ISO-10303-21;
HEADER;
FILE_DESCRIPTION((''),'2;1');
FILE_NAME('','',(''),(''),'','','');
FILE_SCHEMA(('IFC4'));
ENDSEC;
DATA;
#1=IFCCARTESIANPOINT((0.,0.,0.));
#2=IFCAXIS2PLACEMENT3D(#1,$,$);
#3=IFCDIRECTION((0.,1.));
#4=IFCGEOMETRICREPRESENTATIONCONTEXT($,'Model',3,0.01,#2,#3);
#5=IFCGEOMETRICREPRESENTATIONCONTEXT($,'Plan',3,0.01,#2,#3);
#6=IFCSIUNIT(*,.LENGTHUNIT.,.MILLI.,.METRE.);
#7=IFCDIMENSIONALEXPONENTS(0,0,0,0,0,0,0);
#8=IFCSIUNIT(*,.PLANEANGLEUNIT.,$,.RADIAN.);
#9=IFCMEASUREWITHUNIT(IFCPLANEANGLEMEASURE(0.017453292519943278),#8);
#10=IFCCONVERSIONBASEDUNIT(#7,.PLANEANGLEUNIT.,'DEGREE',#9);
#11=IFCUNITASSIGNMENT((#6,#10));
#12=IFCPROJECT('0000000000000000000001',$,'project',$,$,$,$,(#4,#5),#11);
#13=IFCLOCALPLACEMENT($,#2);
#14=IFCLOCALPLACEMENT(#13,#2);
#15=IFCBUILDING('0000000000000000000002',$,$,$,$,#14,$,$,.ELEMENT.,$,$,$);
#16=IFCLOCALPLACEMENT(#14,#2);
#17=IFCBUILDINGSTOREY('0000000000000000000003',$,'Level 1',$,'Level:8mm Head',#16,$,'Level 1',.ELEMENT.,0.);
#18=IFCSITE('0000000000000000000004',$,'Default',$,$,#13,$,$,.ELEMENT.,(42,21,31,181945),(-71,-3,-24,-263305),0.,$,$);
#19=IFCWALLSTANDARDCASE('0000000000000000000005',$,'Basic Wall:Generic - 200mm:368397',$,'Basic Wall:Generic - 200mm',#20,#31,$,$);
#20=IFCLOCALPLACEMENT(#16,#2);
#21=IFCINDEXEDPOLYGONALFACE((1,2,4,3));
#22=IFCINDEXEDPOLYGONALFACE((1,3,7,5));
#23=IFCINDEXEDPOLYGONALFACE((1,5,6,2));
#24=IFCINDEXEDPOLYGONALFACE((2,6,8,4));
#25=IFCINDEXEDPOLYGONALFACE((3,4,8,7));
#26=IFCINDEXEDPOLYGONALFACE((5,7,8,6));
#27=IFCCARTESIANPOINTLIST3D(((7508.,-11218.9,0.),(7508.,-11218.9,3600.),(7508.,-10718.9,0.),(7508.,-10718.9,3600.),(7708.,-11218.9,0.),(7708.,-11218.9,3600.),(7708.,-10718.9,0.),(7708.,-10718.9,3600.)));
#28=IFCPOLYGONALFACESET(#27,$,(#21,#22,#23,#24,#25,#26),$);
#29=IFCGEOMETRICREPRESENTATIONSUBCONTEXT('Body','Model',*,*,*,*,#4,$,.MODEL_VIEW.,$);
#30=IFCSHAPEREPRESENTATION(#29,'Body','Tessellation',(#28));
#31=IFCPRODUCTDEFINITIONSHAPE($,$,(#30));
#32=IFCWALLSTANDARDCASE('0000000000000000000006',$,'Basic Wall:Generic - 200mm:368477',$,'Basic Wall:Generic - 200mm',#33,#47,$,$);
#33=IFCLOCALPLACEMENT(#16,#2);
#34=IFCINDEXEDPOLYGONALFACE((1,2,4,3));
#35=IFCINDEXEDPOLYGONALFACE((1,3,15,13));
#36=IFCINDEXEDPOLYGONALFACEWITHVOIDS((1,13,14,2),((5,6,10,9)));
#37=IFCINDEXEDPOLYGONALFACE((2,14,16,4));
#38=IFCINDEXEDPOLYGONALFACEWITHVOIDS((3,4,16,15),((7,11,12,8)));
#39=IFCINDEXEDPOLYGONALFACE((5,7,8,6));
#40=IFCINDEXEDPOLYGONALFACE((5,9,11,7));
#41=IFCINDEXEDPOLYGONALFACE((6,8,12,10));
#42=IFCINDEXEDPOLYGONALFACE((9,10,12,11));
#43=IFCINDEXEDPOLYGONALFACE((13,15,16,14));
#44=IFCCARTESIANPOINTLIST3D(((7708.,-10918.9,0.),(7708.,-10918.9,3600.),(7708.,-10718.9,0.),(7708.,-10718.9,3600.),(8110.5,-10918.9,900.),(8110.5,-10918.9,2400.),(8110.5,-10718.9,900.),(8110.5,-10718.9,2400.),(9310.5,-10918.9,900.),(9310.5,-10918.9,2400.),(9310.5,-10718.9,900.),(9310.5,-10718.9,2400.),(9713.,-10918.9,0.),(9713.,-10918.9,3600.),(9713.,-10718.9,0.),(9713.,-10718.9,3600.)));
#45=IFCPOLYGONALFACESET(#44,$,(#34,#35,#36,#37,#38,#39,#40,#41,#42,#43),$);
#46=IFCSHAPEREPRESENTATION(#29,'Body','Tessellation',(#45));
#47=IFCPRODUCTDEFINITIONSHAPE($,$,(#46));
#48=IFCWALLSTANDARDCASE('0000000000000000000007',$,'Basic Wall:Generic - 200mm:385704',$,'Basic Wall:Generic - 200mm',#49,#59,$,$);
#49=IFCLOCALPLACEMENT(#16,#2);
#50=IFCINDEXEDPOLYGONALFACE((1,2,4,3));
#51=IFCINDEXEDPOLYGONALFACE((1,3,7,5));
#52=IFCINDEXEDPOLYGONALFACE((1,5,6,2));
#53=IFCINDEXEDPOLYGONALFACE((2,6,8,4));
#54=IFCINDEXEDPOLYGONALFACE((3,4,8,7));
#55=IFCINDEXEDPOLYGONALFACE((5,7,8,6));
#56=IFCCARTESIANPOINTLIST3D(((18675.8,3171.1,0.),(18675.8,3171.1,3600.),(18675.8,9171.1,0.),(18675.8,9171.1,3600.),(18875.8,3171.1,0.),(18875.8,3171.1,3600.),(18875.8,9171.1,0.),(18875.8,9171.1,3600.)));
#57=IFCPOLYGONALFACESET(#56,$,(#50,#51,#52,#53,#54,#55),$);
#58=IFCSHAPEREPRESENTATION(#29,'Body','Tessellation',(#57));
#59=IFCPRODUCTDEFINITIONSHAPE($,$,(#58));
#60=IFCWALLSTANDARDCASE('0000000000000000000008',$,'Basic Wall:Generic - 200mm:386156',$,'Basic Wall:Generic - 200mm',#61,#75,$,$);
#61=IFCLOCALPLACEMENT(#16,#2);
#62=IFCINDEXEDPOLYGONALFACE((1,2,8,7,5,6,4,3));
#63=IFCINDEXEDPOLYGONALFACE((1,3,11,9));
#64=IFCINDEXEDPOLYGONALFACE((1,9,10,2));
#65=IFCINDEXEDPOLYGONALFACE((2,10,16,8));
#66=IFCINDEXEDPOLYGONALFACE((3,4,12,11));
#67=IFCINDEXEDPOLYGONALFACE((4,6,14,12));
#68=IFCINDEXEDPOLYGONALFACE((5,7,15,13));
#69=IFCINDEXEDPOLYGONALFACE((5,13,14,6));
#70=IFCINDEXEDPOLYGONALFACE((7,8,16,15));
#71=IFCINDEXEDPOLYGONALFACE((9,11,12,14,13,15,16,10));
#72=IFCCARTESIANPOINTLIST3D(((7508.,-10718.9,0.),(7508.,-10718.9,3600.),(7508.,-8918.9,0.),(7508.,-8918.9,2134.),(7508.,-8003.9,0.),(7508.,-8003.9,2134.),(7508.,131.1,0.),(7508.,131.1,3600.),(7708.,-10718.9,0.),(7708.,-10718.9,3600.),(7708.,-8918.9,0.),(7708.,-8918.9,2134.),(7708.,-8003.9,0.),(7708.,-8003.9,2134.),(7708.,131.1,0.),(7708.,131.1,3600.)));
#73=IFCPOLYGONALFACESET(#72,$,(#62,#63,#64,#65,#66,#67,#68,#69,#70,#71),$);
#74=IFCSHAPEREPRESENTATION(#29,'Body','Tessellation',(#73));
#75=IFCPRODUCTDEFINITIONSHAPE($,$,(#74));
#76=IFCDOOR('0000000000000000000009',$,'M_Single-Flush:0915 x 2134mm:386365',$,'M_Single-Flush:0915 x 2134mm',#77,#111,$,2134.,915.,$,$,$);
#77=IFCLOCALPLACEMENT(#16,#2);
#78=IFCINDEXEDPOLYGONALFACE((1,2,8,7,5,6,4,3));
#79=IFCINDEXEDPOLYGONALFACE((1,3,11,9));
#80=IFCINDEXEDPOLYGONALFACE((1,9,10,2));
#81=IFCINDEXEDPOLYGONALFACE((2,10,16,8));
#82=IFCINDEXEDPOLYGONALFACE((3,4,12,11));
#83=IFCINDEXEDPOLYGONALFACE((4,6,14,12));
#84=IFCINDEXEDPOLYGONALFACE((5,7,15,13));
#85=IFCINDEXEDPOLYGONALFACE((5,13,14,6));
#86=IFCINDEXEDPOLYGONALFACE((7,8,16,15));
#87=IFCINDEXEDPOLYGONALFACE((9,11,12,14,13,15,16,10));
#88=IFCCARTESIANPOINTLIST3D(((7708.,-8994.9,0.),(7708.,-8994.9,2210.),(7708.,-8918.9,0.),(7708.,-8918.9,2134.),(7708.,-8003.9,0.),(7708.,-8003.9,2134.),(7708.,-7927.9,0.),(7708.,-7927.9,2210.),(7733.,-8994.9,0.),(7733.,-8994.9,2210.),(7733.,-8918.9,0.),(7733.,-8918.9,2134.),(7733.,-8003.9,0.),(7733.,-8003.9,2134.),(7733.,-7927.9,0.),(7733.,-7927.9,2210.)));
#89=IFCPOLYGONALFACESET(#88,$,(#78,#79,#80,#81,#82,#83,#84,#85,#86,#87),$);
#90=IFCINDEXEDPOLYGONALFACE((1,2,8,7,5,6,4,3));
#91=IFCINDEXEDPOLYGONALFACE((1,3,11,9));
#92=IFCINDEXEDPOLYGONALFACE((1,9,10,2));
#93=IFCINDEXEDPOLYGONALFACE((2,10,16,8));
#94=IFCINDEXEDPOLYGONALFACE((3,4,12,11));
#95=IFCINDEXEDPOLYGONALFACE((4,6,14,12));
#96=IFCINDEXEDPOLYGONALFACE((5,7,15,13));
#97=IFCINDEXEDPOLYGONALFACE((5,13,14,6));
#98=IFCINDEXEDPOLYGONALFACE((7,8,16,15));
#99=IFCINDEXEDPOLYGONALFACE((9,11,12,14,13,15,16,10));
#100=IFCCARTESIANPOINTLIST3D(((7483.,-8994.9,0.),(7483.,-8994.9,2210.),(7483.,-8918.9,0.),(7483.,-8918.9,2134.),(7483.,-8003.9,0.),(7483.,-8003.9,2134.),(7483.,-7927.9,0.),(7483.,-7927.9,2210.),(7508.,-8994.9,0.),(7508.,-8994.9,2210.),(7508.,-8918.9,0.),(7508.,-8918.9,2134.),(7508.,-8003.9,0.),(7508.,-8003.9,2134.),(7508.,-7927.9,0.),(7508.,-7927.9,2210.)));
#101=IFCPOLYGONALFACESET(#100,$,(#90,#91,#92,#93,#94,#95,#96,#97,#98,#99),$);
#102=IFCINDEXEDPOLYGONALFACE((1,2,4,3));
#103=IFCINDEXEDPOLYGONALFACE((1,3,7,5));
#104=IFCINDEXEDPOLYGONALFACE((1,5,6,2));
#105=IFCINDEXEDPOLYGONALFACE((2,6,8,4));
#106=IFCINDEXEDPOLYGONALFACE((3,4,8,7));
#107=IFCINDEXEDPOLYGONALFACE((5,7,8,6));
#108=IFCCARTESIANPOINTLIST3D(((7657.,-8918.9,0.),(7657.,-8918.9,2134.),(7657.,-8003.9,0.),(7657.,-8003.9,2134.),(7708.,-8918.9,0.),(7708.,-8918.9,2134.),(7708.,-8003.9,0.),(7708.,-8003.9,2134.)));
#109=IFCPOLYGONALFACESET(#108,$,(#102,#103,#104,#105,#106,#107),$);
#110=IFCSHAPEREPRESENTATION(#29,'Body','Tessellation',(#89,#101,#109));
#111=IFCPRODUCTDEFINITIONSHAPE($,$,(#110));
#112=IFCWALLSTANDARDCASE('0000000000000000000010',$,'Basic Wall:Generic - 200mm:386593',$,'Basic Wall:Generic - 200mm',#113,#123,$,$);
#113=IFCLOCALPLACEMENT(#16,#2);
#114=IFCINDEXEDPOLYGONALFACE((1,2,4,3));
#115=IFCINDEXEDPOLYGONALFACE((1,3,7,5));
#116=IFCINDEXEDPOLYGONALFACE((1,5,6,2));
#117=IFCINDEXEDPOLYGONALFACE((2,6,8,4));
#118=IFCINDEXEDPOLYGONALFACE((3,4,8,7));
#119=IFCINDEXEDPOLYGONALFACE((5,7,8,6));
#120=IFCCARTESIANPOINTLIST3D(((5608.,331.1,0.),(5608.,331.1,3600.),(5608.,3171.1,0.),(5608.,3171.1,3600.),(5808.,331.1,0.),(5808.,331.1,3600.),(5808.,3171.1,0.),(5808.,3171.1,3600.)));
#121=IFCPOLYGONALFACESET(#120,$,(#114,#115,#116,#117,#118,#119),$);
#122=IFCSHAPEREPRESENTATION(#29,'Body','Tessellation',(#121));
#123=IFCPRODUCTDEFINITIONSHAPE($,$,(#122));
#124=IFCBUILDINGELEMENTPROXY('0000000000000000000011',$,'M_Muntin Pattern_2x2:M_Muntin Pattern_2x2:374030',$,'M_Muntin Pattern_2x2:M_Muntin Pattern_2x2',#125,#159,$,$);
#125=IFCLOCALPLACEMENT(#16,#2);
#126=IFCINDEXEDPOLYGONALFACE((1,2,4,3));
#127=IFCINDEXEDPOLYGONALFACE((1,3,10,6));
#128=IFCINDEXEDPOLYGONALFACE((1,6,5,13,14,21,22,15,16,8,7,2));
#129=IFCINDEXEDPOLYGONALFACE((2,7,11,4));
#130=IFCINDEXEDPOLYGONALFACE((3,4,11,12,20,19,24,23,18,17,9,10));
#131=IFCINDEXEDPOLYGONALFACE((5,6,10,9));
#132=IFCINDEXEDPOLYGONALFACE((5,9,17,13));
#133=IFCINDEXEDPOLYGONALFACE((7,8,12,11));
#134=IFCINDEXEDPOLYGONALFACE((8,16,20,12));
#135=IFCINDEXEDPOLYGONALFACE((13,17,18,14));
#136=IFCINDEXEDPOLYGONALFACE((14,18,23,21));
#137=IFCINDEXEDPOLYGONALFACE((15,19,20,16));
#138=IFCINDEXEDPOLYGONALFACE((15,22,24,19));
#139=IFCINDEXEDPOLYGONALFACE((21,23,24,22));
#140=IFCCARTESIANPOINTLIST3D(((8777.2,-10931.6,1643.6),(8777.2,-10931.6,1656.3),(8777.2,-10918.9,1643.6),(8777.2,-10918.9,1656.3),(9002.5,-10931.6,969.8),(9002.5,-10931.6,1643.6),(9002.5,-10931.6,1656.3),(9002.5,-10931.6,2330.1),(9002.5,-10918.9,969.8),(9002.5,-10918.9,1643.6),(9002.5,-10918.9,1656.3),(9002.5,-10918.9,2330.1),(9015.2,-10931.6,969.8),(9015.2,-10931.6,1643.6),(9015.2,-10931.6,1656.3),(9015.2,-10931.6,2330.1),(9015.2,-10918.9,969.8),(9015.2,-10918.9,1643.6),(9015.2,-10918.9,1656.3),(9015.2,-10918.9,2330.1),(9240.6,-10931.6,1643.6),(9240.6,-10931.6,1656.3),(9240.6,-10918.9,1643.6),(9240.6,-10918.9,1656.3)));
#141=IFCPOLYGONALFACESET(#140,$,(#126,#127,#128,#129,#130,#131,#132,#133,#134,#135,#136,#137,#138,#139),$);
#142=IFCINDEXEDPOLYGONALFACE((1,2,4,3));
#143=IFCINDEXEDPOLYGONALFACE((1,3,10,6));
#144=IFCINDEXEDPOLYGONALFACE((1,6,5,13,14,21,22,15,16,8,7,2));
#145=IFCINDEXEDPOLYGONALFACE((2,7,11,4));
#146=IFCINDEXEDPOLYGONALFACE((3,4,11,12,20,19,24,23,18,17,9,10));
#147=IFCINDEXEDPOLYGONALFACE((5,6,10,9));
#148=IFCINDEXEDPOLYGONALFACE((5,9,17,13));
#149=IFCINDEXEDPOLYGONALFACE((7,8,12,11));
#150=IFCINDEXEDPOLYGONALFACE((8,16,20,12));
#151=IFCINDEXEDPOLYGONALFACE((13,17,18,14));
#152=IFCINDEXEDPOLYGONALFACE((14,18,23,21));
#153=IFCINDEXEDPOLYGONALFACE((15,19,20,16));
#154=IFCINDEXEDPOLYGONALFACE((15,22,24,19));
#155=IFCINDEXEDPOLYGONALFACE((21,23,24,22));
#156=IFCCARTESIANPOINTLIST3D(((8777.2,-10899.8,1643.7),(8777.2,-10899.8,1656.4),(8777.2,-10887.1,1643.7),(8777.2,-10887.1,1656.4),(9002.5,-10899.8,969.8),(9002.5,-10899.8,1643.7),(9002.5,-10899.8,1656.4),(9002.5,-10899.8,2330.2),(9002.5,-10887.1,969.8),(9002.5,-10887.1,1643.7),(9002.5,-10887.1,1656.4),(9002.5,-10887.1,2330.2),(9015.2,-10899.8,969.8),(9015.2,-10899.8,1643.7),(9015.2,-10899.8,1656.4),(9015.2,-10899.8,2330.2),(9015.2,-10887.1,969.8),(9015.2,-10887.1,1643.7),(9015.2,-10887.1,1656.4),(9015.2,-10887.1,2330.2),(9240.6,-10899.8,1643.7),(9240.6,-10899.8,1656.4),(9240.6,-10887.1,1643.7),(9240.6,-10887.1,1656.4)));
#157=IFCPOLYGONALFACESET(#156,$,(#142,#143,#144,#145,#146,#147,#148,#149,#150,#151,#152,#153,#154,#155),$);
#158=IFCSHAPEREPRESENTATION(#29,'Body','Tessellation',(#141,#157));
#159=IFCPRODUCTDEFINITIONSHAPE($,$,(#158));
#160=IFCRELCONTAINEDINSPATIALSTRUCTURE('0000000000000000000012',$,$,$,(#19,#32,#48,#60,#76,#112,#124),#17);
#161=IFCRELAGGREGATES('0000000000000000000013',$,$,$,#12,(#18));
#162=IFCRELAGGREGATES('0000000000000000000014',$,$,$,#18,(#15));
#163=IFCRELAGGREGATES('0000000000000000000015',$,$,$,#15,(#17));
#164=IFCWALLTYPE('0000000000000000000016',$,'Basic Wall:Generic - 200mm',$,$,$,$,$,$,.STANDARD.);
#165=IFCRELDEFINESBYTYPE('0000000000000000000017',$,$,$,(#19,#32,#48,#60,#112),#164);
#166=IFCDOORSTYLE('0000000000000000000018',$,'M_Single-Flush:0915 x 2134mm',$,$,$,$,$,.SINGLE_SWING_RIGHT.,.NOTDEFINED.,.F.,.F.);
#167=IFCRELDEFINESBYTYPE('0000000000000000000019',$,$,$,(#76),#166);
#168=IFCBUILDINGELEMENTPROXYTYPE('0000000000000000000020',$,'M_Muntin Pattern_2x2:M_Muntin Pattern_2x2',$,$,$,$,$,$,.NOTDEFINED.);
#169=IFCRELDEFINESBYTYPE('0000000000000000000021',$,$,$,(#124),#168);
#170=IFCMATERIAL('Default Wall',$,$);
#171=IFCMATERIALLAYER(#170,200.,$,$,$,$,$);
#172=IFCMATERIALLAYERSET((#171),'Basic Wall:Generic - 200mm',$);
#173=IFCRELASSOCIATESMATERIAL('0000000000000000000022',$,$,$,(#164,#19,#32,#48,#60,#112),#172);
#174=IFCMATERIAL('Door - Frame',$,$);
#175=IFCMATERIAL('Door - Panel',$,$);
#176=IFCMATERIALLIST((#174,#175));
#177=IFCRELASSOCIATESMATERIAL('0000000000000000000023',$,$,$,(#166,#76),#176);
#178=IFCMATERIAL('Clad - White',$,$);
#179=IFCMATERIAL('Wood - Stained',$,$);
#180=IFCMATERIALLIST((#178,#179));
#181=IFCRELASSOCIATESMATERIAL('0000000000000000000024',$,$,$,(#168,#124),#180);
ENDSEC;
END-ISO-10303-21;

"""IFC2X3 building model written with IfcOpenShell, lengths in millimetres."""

from ifc_helpers import new_model, entity, si_unit, converted_unit, direction, frame, frame_2d, origin, place, context, subcontext, project, spatial, polyline, rectangle, outline, extrude, source, transform, mapped, material, material_list, layer, layer_set, layer_usage, type_object, type_shapes, element, fill, save


model = new_model("IFC2X3")

# Units and contexts
model_context = context("Model", 3, precision=0.01, world=origin(), true_north=direction((0.0, 1.0)))
plan_context = context("Plan", 3, precision=0.01, world=origin(), true_north=direction((0.0, 1.0)))
body_context = subcontext(model_context, "Body", "Model", "MODEL_VIEW")
ifc_project = project(units=[si_unit("LENGTHUNIT", "METRE", prefix="MILLI"), converted_unit("PLANEANGLEUNIT", "DEGREE", entity("IfcPlaneAngleMeasure", 0.017453292519943278), si_unit("PLANEANGLEUNIT", "RADIAN"), dimensions=[0, 0, 0, 0, 0, 0, 0])], contexts=[model_context, plan_context])

# Site, building, storey
site_placement = place(None, origin())
site = spatial("IfcSite", under=ifc_project, at=site_placement, Name="Default", CompositionType="ELEMENT", RefLatitude=(42, 21, 31, 181945), RefLongitude=(-71, -3, -24, -263305), RefElevation=0.0)
building_placement = place(site_placement, origin())
building = spatial("IfcBuilding", under=site, at=building_placement, CompositionType="ELEMENT")
storey_placement = place(building_placement, origin())
storey = spatial("IfcBuildingStorey", under=building, at=storey_placement, Name="Level 1", ObjectType="Level:8mm Head", LongName="Level 1", CompositionType="ELEMENT", Elevation=0.0)

# Wall
ifc_material_1 = material(Name="Default Wall")
ifc_layer = layer(ifc_material_1, 200.0)
ifc_layer_set = layer_set([ifc_layer], Name="Basic Wall:Generic - 200mm")
ifc_layer_usage_1 = layer_usage(ifc_layer_set, "AXIS2", "NEGATIVE", 100.0)
wall_type = type_object("IfcWallType", Name="Basic Wall:Generic - 200mm", PredefinedType="STANDARD", material=ifc_layer_set)
wall_1_placement = place(storey_placement, frame((7608.0, -11218.9, 0.0), z_axis=(0.0, 0.0, 1.0), x_axis=(0.0, 1.0, 0.0)))
element("IfcWallStandardCase", 1, at=wall_1_placement, inside=storey, type_object=wall_type, material=ifc_layer_usage_1, Name="Basic Wall:Generic - 200mm:368397", ObjectType="Basic Wall:Generic - 200mm", context=body_context, shape_type="SweptSolid", body=[
    extrude(rectangle(XDim=500.0, YDim=200.0, at=frame_2d((250.0, 0.0), x_axis=(-1.0, 0.0))), origin(), (0.0, 0.0, 1.0), 3600.0),
])

# Wall, opening
ifc_layer_usage_2 = layer_usage(ifc_layer_set, "AXIS2", "NEGATIVE", 100.0)
wall_2_placement = place(storey_placement, frame((7708.0, -10818.9, 0.0)))
wall_2 = element("IfcWallStandardCase", 2, at=wall_2_placement, inside=storey, type_object=wall_type, material=ifc_layer_usage_2, Name="Basic Wall:Generic - 200mm:368477", ObjectType="Basic Wall:Generic - 200mm", context=body_context, shape_type="SweptSolid", body=[
    extrude(rectangle(XDim=2005.0, YDim=200.0, at=frame_2d((1002.5, 0.0), x_axis=(-1.0, 0.0))), origin(), (0.0, 0.0, 1.0), 3600.0),
])
opening_1_placement = place(wall_2_placement, frame((1602.5, 100.0, 900.0)))
element("IfcOpeningElement", 3, at=opening_1_placement, cuts=wall_2, ObjectType="Opening", context=body_context, shape_type="SweptSolid", body=[
    extrude(rectangle(XDim=1500.0, YDim=1200.0, at=frame_2d((750.0, 600.0), x_axis=(-1.0, 0.0))), frame((0.0, 0.0, 0.0), z_axis=(0.0, -1.0, 0.0), x_axis=(0.0, 0.0, 1.0)), (0.0, 0.0, 1.0), 200.0),
])

# Wall
ifc_layer_usage_3 = layer_usage(ifc_layer_set, "AXIS2", "NEGATIVE", 100.0)
wall_3_placement = place(storey_placement, frame((18775.8, 9171.1, 0.0), z_axis=(0.0, 0.0, 1.0), x_axis=(0.0, -1.0, 0.0)))
element("IfcWallStandardCase", 4, at=wall_3_placement, inside=storey, type_object=wall_type, material=ifc_layer_usage_3, Name="Basic Wall:Generic - 200mm:385704", ObjectType="Basic Wall:Generic - 200mm", context=body_context, shape_type="SweptSolid", body=[
    extrude(rectangle(XDim=6000.0, YDim=200.0, at=frame_2d((3000.0, 0.0), x_axis=(-1.0, 0.0))), origin(), (0.0, 0.0, 1.0), 3600.0),
])

# Wall, opening, door
ifc_layer_usage_4 = layer_usage(ifc_layer_set, "AXIS2", "NEGATIVE", 100.0)
wall_4_placement = place(storey_placement, frame((7608.0, 131.1, 0.0), z_axis=(0.0, 0.0, 1.0), x_axis=(0.0, -1.0, 0.0)))
wall_4 = element("IfcWallStandardCase", 5, at=wall_4_placement, inside=storey, type_object=wall_type, material=ifc_layer_usage_4, Name="Basic Wall:Generic - 200mm:386156", ObjectType="Basic Wall:Generic - 200mm", context=body_context, shape_type="SweptSolid", body=[
    extrude(rectangle(XDim=10850.0, YDim=200.0, at=frame_2d((5425.0, 0.0), x_axis=(1.0, 0.0))), origin(), (0.0, 0.0, 1.0), 3600.0),
])
opening_2_placement = place(wall_4_placement, frame((8135.0, -100.0, 0.0)))
opening_2 = element("IfcOpeningElement", 6, at=opening_2_placement, cuts=wall_4, ObjectType="Opening", context=body_context, shape_type="SweptSolid", body=[
    extrude(rectangle(XDim=915.0, YDim=2134.0, at=frame_2d((1067.0, 457.5), x_axis=(0.0, 1.0))), frame((0.0, 0.0, 0.0), z_axis=(0.0, 1.0, 0.0), x_axis=(0.0, 0.0, 1.0)), (0.0, 0.0, 1.0), 200.0),
])
ifc_material_2 = material(Name="Door - Frame")
ifc_material_3 = material(Name="Door - Panel")
ifc_material_list_1 = material_list([ifc_material_2, ifc_material_3])
door_style = type_object("IfcDoorStyle", Name="M_Single-Flush:0915 x 2134mm", ConstructionType="NOTDEFINED", OperationType="SINGLE_SWING_RIGHT", ParameterTakesPrecedence=False, Sizeable=False, material=ifc_material_list_1)
shared_shape_1 = source(origin(), body_context, "Body", "SweptSolid", [
    extrude(outline(polyline([(-533.5, -1124.0), (533.5, -1124.0), (533.5, 1086.0), (457.5, 1086.0), (457.5, -1048.0), (-457.5, -1048.0), (-457.5, 1086.0), (-533.5, 1086.0), (-533.5, -1124.0)])), frame((457.5, 200.0, 1086.0), z_axis=(0.0, 1.0, 0.0), x_axis=(1.0, 0.0, 0.0)), (0.0, 0.0, 1.0), 25.0),
    extrude(outline(polyline([(-1124.0, -533.5), (1086.0, -533.5), (1086.0, -457.5), (-1048.0, -457.5), (-1048.0, 457.5), (1086.0, 457.5), (1086.0, 533.5), (-1124.0, 533.5), (-1124.0, -533.5)])), frame((457.5, -25.0, 1086.0), z_axis=(0.0, 1.0, 0.0), x_axis=(0.0, 0.0, -1.0)), (0.0, 0.0, 1.0), 25.0),
    extrude(rectangle(XDim=51.0, YDim=915.0, at=frame_2d((0.0, 0.0), x_axis=(1.0, 0.0))), frame((457.5, 174.5, 0.0), z_axis=(0.0, 0.0, 1.0), x_axis=(0.0, 1.0, 0.0)), (0.0, 0.0, 1.0), 2134.0),
])
type_shapes(door_style, [shared_shape_1])
door_1_placement = place(opening_2_placement, origin())
door_1 = element("IfcDoor", 7, at=door_1_placement, inside=storey, type_object=door_style, material=ifc_material_list_1, Name="M_Single-Flush:0915 x 2134mm:386365", ObjectType="M_Single-Flush:0915 x 2134mm", OverallHeight=2134.0, OverallWidth=915.0, context=body_context, shape_type="MappedRepresentation", body=[
    mapped(shared_shape_1, transform((0.0, 0.0, 0.0), scale=1.0)),
])
fill(opening_2, door_1)

# Wall
ifc_layer_usage_5 = layer_usage(ifc_layer_set, "AXIS2", "NEGATIVE", 100.0)
wall_5_placement = place(storey_placement, frame((5708.0, 331.1, 0.0), z_axis=(0.0, 0.0, 1.0), x_axis=(0.0, 1.0, 0.0)))
element("IfcWallStandardCase", 8, at=wall_5_placement, inside=storey, type_object=wall_type, material=ifc_layer_usage_5, Name="Basic Wall:Generic - 200mm:386593", ObjectType="Basic Wall:Generic - 200mm", context=body_context, shape_type="SweptSolid", body=[
    extrude(rectangle(XDim=2840.0, YDim=200.0, at=frame_2d((1420.0, 0.0), x_axis=(-1.0, 0.0))), origin(), (0.0, 0.0, 1.0), 3600.0),
])

# Building element proxy
ifc_material_4 = material(Name="Clad - White")
ifc_material_5 = material(Name="Wood - Stained")
ifc_material_list_2 = material_list([ifc_material_4, ifc_material_5])
building_element_proxy_type_1 = type_object("IfcBuildingElementProxyType", Name="M_Muntin Pattern_2x2:M_Muntin Pattern_2x2", PredefinedType="NOTDEFINED", material=ifc_material_list_2)
shared_shape_2 = source(origin(), body_context, "Body", "SweptSolid", [
    extrude(outline(polyline([(6.4, -6.4), (680.1, -6.4), (680.1, 6.3), (6.4, 6.3), (6.4, 231.7), (-6.3, 231.7), (-6.3, 6.3), (-680.2, 6.3), (-680.2, -6.4), (-6.3, -6.4), (-6.3, -231.7), (6.4, -231.7), (6.4, -6.4)])), frame((0.0, 9.5, 680.1), z_axis=(0.0, 1.0, 0.0), x_axis=(0.0, 0.0, 1.0)), (0.0, 0.0, 1.0), 12.7),
    extrude(outline(polyline([(6.4, -6.4), (680.2, -6.4), (680.2, 6.3), (6.4, 6.3), (6.4, 231.7), (-6.3, 231.7), (-6.3, 6.3), (-680.2, 6.3), (-680.2, -6.4), (-6.3, -6.4), (-6.3, -231.7), (6.4, -231.7), (6.4, -6.4)])), frame((0.0, -22.2, 680.2), z_axis=(0.0, 1.0, 0.0), x_axis=(0.0, 0.0, 1.0)), (0.0, 0.0, 1.0), 12.7),
])
type_shapes(building_element_proxy_type_1, [shared_shape_2])
proxy_1_placement = place(storey_placement, frame((9008.9, -10909.4, 969.8), z_axis=(0.0, 0.0, 1.0), x_axis=(-1.0, 0.0, 0.0)))
element("IfcBuildingElementProxy", 9, at=proxy_1_placement, inside=storey, type_object=building_element_proxy_type_1, material=ifc_material_list_2, Name="M_Muntin Pattern_2x2:M_Muntin Pattern_2x2:374030", ObjectType="M_Muntin Pattern_2x2:M_Muntin Pattern_2x2", context=body_context, shape_type="MappedRepresentation", body=[
    mapped(shared_shape_2, transform((0.0, 0.0, 0.0), scale=1.0)),
])

save(model, "model.ifc")
